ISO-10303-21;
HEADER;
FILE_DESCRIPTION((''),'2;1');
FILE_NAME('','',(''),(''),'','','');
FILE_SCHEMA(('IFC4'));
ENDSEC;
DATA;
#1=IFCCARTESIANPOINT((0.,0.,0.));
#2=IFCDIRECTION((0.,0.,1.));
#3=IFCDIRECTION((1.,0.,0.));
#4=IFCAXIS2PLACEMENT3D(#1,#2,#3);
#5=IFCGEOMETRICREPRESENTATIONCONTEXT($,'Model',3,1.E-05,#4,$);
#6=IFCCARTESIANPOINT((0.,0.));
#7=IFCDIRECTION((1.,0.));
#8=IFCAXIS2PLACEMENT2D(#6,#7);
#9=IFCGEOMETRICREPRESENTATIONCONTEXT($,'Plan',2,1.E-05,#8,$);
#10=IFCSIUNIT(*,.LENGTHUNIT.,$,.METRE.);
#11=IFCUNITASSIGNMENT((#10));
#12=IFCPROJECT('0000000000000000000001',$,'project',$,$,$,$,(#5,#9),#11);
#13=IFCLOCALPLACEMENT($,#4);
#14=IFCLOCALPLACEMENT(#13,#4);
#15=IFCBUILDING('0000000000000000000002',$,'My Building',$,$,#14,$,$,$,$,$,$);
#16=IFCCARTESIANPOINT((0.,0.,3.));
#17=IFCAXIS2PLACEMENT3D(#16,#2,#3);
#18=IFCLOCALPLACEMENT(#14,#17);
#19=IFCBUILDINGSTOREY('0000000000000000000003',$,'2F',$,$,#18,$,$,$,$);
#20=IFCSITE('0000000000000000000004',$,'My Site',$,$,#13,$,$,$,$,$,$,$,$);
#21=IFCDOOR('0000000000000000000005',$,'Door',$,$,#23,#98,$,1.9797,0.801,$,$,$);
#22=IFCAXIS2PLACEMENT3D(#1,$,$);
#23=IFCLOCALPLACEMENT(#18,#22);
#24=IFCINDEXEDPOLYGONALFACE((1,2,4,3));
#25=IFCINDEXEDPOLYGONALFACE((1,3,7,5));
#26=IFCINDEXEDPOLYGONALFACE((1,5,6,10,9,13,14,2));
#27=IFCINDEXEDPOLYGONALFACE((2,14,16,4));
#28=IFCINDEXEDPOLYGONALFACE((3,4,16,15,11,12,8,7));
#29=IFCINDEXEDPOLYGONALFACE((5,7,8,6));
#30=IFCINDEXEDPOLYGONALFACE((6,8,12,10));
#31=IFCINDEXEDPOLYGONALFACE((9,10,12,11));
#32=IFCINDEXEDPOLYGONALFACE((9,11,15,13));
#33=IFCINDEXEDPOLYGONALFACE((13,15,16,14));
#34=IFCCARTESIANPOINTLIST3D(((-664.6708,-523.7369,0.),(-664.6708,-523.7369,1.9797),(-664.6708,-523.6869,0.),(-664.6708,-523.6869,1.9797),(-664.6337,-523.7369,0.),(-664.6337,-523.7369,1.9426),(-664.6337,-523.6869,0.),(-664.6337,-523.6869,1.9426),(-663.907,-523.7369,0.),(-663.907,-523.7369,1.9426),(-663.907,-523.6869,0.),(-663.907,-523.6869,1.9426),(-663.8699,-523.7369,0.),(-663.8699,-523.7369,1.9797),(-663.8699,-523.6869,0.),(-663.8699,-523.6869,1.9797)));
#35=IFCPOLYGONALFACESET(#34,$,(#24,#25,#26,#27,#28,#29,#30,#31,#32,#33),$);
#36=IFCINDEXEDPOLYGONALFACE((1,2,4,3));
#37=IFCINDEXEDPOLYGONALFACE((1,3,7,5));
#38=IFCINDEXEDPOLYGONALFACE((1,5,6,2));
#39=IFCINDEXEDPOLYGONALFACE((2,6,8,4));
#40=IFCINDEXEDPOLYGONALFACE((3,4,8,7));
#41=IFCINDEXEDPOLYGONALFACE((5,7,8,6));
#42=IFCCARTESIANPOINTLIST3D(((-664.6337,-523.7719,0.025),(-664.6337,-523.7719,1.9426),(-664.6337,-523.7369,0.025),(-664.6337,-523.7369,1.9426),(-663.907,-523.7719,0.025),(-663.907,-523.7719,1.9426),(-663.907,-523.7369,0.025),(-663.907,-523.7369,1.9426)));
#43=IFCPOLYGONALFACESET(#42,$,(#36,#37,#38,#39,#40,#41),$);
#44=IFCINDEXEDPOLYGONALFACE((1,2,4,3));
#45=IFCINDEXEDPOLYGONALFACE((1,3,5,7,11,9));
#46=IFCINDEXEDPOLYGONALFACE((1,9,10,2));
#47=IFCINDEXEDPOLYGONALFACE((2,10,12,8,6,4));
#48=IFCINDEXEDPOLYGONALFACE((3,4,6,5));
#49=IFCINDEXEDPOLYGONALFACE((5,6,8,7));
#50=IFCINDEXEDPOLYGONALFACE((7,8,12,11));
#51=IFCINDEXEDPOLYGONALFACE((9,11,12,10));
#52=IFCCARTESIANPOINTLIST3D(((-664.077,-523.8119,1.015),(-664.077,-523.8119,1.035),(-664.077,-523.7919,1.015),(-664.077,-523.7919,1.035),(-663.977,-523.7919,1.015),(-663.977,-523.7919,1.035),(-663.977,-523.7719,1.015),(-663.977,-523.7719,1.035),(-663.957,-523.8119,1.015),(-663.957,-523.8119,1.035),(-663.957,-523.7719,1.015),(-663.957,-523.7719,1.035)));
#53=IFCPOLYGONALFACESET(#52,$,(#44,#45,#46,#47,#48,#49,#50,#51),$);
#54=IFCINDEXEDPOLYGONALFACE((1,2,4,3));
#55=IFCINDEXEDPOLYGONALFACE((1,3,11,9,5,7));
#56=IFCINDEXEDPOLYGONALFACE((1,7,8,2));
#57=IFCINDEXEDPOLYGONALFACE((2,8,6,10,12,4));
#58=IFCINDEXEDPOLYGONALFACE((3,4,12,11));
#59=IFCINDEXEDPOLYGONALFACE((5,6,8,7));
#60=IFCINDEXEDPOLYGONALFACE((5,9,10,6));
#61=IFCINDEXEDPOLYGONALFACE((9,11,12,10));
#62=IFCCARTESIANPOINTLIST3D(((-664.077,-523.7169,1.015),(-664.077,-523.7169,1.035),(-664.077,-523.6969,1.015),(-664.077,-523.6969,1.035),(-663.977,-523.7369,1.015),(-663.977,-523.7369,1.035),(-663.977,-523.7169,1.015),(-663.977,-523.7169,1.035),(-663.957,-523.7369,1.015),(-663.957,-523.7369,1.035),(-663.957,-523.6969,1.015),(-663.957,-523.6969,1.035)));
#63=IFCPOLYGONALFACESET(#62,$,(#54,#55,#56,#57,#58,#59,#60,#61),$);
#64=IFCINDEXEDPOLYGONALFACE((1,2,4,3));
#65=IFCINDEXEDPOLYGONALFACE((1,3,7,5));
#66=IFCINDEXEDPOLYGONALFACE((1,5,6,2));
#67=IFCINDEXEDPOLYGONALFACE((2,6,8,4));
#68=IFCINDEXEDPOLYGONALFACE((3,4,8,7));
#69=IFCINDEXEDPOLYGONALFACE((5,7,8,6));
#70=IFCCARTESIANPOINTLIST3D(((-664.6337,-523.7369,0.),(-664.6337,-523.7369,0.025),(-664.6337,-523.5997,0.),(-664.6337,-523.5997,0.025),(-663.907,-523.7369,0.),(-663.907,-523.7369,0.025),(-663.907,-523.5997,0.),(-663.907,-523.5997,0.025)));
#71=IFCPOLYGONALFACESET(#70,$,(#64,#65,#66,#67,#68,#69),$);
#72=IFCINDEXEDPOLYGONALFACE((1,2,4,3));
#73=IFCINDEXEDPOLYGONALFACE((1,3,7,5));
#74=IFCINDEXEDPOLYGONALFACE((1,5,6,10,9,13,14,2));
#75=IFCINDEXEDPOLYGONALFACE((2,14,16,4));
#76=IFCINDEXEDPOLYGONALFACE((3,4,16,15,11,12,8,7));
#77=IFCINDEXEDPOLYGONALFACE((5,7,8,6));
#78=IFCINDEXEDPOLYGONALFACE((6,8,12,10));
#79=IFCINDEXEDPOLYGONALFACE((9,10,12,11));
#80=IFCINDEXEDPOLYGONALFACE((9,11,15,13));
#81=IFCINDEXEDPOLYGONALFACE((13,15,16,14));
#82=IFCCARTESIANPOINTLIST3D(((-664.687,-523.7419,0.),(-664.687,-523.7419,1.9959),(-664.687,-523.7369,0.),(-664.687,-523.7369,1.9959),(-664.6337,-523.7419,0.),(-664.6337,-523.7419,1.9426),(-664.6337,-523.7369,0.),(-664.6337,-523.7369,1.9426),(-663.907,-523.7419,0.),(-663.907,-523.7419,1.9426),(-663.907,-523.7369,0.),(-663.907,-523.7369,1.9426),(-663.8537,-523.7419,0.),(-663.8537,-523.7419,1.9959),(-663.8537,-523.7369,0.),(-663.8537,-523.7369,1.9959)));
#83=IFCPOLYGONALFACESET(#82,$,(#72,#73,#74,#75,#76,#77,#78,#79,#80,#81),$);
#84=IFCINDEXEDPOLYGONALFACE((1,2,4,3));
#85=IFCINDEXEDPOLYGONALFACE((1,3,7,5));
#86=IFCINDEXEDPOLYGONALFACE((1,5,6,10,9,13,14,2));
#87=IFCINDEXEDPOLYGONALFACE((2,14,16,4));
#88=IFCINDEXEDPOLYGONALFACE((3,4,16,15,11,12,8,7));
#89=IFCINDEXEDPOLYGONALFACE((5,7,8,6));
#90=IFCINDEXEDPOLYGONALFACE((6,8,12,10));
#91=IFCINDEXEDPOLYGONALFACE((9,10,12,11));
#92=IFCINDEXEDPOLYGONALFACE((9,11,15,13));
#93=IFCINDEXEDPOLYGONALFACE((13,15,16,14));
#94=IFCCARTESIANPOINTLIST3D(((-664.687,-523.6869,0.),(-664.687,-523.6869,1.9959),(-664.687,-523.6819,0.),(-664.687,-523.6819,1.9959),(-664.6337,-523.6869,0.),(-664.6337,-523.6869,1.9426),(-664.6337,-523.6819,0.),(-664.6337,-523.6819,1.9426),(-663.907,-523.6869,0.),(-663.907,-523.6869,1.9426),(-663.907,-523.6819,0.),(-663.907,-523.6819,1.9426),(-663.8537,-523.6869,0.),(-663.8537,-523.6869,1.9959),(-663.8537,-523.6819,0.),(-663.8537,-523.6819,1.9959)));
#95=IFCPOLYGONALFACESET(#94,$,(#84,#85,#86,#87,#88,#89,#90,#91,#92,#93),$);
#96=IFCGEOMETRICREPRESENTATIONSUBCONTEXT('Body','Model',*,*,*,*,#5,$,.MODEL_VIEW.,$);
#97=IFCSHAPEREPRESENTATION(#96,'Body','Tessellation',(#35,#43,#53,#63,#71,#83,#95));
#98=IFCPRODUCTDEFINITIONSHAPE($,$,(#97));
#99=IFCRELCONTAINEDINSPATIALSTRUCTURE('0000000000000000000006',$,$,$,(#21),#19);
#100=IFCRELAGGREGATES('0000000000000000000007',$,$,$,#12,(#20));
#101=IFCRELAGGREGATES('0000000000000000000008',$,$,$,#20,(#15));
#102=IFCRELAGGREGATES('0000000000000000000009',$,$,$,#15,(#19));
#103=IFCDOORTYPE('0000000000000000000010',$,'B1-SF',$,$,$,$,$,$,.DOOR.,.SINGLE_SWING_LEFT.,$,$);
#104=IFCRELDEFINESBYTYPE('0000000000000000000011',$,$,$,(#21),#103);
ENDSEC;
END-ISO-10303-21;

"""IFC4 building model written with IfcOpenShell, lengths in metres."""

from ifc_helpers import new_model, entity, si_unit, frame, origin_with_axes, origin_2d_with_axis, place, context, subcontext, project, spatial, line, indexed_curve, outline, extrude, shape, source, transform, mapped, type_object, type_shapes, element, save


model = new_model("IFC4")

# Units and contexts
model_context = context("Model", 3, precision=1e-05, world=origin_with_axes())
plan_context = context("Plan", 2, precision=1e-05, world=origin_2d_with_axis())
body_context_1 = subcontext(model_context, "Body", "Model", "MODEL_VIEW")
body_context_2 = subcontext(plan_context, "Body", "Plan", "PLAN_VIEW")
ifc_project = project(units=[si_unit("LENGTHUNIT", "METRE")], contexts=[model_context, plan_context])

# Site, building, storey
site_placement = place(None, origin_with_axes())
site = spatial("IfcSite", under=ifc_project, at=site_placement, Name="My Site")
building_placement = place(site_placement, origin_with_axes())
building = spatial("IfcBuilding", under=site, at=building_placement, Name="My Building")
storey_placement = place(building_placement, frame((0.0, 0.0, 3.0), z_axis=(0.0, 0.0, 1.0), x_axis=(1.0, 0.0, 0.0)))
storey = spatial("IfcBuildingStorey", under=building, at=storey_placement, Name="2F")

# Shared definitions
door_type_1 = type_object("IfcDoorType", Name="B1-SF", OperationType="SINGLE_SWING_LEFT", PredefinedType="DOOR")
shared_shape_1 = source(origin_with_axes(), body_context_1, "Body", "SweptSolid", [
    extrude(outline(indexed_curve([(0.0, 0.0), (0.0, 1.9797), (0.801, 1.9797), (0.801, 0.0), (0.7639, 0.0), (0.7639, 1.9426), (0.0371, 1.9426), (0.0371, 0.0)], segments=[line(1, 2, 3, 4, 5, 6, 7, 8, 1)])), frame((0.0, 0.0, 0.0), z_axis=(0.0, -1.0, 0.0), x_axis=(1.0, 0.0, 0.0)), (0.0, 0.0, -1.0), 0.05),
    extrude(outline(indexed_curve([(0.0, 0.0), (0.7268, 0.0), (0.7268, 0.035), (0.0, 0.035)], segments=[line(1, 2, 3, 4, 1)])), frame((0.0371, -0.035, 0.025), z_axis=(0.0, 0.0, 1.0), x_axis=(1.0, 0.0, 0.0)), (0.0, 0.0, 1.0), 1.9176),
    extrude(outline(indexed_curve([(0.0, 0.0), (0.0, -0.04), (-0.12, -0.04), (-0.12, -0.02), (-0.02, -0.02), (-0.02, 0.0)], segments=[line(1, 2, 3, 4, 5, 6, 1)])), frame((0.7139, -0.035, 1.015), z_axis=(0.0, 0.0, 1.0), x_axis=(1.0, 0.0, 0.0)), (0.0, 0.0, 1.0), 0.02),
    extrude(outline(indexed_curve([(0.0, 0.0), (0.0, 0.04), (-0.12, 0.04), (-0.12, 0.02), (-0.02, 0.02), (-0.02, 0.0)], segments=[line(1, 2, 3, 4, 5, 6, 1)])), frame((0.7139, 0.0, 1.015), z_axis=(0.0, 0.0, 1.0), x_axis=(1.0, 0.0, 0.0)), (0.0, 0.0, 1.0), 0.02),
    extrude(outline(indexed_curve([(0.0, 0.0), (0.7268, 0.0), (0.7268, 0.1372), (0.0, 0.1372)], segments=[line(1, 2, 3, 4, 1)])), frame((0.0371, 0.0, 0.0), z_axis=(0.0, 0.0, 1.0), x_axis=(1.0, 0.0, 0.0)), (0.0, 0.0, 1.0), 0.025),
    extrude(outline(indexed_curve([(0.0, 0.0), (0.0, 1.9959), (0.8333, 1.9959), (0.8333, 0.0), (0.78, 0.0), (0.78, 1.9426), (0.0532, 1.9426), (0.0532, 0.0)], segments=[line(1, 2, 3, 4, 5, 6, 7, 8, 1)])), frame((-0.0162, -0.005, 0.0), z_axis=(0.0, -1.0, 0.0), x_axis=(1.0, 0.0, 0.0)), (0.0, 0.0, -1.0), 0.005),
    extrude(outline(indexed_curve([(0.0, 0.0), (0.0, 1.9959), (0.8333, 1.9959), (0.8333, 0.0), (0.78, 0.0), (0.78, 1.9426), (0.0532, 1.9426), (0.0532, 0.0)], segments=[line(1, 2, 3, 4, 5, 6, 7, 8, 1)])), frame((-0.0162, 0.05, 0.0), z_axis=(0.0, -1.0, 0.0), x_axis=(1.0, 0.0, 0.0)), (0.0, 0.0, -1.0), 0.005),
])
shared_shape_2 = source(origin_with_axes(), body_context_2, "Body", "Curve2D", [
    entity("IfcIndexedPolyCurve", entity("IfcCartesianPointList2D", [[0.0, 0.0], [0.0371, 0.0], [0.0371, 0.05], [0.0, 0.05]]), [entity("IfcLineIndex", [1, 2, 3, 4, 1])]),
    entity("IfcIndexedPolyCurve", entity("IfcCartesianPointList2D", [[0.801, 0.0], [0.7639, 0.0], [0.7639, 0.05], [0.801, 0.05]]), [entity("IfcLineIndex", [1, 2, 3, 4, 1])]),
    entity("IfcIndexedPolyCurve", entity("IfcCartesianPointList2D", [[-0.3263, -0.035], [0.4005, -0.035], [0.4005, 0.0], [-0.3263, 0.0]]), [entity("IfcLineIndex", [1, 2, 3, 4, 1])]),
])
type_shapes(door_type_1, [shared_shape_1, shared_shape_2])

# Door
door_1_placement = place(storey_placement, frame((-664.6708, -523.7369, 0.0), z_axis=(0.0, 0.0, 1.0), x_axis=(1.0, 0.0, 0.0)))
element("IfcDoor", 1, at=door_1_placement, inside=storey, type_object=door_type_1, Name="Door", OverallHeight=1.9797, OverallWidth=0.801, shapes=[
    shape(body_context_1, "Body", "MappedRepresentation", [mapped(shared_shape_1, transform((0.0, 0.0, 0.0), x_axis=(1.0, 0.0, 0.0), y_axis=(0.0, 1.0, 0.0), z_axis=(0.0, 0.0, 1.0), scale=1.0))]),
    shape(body_context_2, "Body", "MappedRepresentation", [mapped(shared_shape_2, transform((0.0, 0.0, 0.0), x_axis=(1.0, 0.0, 0.0), y_axis=(0.0, 1.0, 0.0), z_axis=(0.0, 0.0, 1.0), scale=1.0))]),
])

save(model, "model.ifc")
